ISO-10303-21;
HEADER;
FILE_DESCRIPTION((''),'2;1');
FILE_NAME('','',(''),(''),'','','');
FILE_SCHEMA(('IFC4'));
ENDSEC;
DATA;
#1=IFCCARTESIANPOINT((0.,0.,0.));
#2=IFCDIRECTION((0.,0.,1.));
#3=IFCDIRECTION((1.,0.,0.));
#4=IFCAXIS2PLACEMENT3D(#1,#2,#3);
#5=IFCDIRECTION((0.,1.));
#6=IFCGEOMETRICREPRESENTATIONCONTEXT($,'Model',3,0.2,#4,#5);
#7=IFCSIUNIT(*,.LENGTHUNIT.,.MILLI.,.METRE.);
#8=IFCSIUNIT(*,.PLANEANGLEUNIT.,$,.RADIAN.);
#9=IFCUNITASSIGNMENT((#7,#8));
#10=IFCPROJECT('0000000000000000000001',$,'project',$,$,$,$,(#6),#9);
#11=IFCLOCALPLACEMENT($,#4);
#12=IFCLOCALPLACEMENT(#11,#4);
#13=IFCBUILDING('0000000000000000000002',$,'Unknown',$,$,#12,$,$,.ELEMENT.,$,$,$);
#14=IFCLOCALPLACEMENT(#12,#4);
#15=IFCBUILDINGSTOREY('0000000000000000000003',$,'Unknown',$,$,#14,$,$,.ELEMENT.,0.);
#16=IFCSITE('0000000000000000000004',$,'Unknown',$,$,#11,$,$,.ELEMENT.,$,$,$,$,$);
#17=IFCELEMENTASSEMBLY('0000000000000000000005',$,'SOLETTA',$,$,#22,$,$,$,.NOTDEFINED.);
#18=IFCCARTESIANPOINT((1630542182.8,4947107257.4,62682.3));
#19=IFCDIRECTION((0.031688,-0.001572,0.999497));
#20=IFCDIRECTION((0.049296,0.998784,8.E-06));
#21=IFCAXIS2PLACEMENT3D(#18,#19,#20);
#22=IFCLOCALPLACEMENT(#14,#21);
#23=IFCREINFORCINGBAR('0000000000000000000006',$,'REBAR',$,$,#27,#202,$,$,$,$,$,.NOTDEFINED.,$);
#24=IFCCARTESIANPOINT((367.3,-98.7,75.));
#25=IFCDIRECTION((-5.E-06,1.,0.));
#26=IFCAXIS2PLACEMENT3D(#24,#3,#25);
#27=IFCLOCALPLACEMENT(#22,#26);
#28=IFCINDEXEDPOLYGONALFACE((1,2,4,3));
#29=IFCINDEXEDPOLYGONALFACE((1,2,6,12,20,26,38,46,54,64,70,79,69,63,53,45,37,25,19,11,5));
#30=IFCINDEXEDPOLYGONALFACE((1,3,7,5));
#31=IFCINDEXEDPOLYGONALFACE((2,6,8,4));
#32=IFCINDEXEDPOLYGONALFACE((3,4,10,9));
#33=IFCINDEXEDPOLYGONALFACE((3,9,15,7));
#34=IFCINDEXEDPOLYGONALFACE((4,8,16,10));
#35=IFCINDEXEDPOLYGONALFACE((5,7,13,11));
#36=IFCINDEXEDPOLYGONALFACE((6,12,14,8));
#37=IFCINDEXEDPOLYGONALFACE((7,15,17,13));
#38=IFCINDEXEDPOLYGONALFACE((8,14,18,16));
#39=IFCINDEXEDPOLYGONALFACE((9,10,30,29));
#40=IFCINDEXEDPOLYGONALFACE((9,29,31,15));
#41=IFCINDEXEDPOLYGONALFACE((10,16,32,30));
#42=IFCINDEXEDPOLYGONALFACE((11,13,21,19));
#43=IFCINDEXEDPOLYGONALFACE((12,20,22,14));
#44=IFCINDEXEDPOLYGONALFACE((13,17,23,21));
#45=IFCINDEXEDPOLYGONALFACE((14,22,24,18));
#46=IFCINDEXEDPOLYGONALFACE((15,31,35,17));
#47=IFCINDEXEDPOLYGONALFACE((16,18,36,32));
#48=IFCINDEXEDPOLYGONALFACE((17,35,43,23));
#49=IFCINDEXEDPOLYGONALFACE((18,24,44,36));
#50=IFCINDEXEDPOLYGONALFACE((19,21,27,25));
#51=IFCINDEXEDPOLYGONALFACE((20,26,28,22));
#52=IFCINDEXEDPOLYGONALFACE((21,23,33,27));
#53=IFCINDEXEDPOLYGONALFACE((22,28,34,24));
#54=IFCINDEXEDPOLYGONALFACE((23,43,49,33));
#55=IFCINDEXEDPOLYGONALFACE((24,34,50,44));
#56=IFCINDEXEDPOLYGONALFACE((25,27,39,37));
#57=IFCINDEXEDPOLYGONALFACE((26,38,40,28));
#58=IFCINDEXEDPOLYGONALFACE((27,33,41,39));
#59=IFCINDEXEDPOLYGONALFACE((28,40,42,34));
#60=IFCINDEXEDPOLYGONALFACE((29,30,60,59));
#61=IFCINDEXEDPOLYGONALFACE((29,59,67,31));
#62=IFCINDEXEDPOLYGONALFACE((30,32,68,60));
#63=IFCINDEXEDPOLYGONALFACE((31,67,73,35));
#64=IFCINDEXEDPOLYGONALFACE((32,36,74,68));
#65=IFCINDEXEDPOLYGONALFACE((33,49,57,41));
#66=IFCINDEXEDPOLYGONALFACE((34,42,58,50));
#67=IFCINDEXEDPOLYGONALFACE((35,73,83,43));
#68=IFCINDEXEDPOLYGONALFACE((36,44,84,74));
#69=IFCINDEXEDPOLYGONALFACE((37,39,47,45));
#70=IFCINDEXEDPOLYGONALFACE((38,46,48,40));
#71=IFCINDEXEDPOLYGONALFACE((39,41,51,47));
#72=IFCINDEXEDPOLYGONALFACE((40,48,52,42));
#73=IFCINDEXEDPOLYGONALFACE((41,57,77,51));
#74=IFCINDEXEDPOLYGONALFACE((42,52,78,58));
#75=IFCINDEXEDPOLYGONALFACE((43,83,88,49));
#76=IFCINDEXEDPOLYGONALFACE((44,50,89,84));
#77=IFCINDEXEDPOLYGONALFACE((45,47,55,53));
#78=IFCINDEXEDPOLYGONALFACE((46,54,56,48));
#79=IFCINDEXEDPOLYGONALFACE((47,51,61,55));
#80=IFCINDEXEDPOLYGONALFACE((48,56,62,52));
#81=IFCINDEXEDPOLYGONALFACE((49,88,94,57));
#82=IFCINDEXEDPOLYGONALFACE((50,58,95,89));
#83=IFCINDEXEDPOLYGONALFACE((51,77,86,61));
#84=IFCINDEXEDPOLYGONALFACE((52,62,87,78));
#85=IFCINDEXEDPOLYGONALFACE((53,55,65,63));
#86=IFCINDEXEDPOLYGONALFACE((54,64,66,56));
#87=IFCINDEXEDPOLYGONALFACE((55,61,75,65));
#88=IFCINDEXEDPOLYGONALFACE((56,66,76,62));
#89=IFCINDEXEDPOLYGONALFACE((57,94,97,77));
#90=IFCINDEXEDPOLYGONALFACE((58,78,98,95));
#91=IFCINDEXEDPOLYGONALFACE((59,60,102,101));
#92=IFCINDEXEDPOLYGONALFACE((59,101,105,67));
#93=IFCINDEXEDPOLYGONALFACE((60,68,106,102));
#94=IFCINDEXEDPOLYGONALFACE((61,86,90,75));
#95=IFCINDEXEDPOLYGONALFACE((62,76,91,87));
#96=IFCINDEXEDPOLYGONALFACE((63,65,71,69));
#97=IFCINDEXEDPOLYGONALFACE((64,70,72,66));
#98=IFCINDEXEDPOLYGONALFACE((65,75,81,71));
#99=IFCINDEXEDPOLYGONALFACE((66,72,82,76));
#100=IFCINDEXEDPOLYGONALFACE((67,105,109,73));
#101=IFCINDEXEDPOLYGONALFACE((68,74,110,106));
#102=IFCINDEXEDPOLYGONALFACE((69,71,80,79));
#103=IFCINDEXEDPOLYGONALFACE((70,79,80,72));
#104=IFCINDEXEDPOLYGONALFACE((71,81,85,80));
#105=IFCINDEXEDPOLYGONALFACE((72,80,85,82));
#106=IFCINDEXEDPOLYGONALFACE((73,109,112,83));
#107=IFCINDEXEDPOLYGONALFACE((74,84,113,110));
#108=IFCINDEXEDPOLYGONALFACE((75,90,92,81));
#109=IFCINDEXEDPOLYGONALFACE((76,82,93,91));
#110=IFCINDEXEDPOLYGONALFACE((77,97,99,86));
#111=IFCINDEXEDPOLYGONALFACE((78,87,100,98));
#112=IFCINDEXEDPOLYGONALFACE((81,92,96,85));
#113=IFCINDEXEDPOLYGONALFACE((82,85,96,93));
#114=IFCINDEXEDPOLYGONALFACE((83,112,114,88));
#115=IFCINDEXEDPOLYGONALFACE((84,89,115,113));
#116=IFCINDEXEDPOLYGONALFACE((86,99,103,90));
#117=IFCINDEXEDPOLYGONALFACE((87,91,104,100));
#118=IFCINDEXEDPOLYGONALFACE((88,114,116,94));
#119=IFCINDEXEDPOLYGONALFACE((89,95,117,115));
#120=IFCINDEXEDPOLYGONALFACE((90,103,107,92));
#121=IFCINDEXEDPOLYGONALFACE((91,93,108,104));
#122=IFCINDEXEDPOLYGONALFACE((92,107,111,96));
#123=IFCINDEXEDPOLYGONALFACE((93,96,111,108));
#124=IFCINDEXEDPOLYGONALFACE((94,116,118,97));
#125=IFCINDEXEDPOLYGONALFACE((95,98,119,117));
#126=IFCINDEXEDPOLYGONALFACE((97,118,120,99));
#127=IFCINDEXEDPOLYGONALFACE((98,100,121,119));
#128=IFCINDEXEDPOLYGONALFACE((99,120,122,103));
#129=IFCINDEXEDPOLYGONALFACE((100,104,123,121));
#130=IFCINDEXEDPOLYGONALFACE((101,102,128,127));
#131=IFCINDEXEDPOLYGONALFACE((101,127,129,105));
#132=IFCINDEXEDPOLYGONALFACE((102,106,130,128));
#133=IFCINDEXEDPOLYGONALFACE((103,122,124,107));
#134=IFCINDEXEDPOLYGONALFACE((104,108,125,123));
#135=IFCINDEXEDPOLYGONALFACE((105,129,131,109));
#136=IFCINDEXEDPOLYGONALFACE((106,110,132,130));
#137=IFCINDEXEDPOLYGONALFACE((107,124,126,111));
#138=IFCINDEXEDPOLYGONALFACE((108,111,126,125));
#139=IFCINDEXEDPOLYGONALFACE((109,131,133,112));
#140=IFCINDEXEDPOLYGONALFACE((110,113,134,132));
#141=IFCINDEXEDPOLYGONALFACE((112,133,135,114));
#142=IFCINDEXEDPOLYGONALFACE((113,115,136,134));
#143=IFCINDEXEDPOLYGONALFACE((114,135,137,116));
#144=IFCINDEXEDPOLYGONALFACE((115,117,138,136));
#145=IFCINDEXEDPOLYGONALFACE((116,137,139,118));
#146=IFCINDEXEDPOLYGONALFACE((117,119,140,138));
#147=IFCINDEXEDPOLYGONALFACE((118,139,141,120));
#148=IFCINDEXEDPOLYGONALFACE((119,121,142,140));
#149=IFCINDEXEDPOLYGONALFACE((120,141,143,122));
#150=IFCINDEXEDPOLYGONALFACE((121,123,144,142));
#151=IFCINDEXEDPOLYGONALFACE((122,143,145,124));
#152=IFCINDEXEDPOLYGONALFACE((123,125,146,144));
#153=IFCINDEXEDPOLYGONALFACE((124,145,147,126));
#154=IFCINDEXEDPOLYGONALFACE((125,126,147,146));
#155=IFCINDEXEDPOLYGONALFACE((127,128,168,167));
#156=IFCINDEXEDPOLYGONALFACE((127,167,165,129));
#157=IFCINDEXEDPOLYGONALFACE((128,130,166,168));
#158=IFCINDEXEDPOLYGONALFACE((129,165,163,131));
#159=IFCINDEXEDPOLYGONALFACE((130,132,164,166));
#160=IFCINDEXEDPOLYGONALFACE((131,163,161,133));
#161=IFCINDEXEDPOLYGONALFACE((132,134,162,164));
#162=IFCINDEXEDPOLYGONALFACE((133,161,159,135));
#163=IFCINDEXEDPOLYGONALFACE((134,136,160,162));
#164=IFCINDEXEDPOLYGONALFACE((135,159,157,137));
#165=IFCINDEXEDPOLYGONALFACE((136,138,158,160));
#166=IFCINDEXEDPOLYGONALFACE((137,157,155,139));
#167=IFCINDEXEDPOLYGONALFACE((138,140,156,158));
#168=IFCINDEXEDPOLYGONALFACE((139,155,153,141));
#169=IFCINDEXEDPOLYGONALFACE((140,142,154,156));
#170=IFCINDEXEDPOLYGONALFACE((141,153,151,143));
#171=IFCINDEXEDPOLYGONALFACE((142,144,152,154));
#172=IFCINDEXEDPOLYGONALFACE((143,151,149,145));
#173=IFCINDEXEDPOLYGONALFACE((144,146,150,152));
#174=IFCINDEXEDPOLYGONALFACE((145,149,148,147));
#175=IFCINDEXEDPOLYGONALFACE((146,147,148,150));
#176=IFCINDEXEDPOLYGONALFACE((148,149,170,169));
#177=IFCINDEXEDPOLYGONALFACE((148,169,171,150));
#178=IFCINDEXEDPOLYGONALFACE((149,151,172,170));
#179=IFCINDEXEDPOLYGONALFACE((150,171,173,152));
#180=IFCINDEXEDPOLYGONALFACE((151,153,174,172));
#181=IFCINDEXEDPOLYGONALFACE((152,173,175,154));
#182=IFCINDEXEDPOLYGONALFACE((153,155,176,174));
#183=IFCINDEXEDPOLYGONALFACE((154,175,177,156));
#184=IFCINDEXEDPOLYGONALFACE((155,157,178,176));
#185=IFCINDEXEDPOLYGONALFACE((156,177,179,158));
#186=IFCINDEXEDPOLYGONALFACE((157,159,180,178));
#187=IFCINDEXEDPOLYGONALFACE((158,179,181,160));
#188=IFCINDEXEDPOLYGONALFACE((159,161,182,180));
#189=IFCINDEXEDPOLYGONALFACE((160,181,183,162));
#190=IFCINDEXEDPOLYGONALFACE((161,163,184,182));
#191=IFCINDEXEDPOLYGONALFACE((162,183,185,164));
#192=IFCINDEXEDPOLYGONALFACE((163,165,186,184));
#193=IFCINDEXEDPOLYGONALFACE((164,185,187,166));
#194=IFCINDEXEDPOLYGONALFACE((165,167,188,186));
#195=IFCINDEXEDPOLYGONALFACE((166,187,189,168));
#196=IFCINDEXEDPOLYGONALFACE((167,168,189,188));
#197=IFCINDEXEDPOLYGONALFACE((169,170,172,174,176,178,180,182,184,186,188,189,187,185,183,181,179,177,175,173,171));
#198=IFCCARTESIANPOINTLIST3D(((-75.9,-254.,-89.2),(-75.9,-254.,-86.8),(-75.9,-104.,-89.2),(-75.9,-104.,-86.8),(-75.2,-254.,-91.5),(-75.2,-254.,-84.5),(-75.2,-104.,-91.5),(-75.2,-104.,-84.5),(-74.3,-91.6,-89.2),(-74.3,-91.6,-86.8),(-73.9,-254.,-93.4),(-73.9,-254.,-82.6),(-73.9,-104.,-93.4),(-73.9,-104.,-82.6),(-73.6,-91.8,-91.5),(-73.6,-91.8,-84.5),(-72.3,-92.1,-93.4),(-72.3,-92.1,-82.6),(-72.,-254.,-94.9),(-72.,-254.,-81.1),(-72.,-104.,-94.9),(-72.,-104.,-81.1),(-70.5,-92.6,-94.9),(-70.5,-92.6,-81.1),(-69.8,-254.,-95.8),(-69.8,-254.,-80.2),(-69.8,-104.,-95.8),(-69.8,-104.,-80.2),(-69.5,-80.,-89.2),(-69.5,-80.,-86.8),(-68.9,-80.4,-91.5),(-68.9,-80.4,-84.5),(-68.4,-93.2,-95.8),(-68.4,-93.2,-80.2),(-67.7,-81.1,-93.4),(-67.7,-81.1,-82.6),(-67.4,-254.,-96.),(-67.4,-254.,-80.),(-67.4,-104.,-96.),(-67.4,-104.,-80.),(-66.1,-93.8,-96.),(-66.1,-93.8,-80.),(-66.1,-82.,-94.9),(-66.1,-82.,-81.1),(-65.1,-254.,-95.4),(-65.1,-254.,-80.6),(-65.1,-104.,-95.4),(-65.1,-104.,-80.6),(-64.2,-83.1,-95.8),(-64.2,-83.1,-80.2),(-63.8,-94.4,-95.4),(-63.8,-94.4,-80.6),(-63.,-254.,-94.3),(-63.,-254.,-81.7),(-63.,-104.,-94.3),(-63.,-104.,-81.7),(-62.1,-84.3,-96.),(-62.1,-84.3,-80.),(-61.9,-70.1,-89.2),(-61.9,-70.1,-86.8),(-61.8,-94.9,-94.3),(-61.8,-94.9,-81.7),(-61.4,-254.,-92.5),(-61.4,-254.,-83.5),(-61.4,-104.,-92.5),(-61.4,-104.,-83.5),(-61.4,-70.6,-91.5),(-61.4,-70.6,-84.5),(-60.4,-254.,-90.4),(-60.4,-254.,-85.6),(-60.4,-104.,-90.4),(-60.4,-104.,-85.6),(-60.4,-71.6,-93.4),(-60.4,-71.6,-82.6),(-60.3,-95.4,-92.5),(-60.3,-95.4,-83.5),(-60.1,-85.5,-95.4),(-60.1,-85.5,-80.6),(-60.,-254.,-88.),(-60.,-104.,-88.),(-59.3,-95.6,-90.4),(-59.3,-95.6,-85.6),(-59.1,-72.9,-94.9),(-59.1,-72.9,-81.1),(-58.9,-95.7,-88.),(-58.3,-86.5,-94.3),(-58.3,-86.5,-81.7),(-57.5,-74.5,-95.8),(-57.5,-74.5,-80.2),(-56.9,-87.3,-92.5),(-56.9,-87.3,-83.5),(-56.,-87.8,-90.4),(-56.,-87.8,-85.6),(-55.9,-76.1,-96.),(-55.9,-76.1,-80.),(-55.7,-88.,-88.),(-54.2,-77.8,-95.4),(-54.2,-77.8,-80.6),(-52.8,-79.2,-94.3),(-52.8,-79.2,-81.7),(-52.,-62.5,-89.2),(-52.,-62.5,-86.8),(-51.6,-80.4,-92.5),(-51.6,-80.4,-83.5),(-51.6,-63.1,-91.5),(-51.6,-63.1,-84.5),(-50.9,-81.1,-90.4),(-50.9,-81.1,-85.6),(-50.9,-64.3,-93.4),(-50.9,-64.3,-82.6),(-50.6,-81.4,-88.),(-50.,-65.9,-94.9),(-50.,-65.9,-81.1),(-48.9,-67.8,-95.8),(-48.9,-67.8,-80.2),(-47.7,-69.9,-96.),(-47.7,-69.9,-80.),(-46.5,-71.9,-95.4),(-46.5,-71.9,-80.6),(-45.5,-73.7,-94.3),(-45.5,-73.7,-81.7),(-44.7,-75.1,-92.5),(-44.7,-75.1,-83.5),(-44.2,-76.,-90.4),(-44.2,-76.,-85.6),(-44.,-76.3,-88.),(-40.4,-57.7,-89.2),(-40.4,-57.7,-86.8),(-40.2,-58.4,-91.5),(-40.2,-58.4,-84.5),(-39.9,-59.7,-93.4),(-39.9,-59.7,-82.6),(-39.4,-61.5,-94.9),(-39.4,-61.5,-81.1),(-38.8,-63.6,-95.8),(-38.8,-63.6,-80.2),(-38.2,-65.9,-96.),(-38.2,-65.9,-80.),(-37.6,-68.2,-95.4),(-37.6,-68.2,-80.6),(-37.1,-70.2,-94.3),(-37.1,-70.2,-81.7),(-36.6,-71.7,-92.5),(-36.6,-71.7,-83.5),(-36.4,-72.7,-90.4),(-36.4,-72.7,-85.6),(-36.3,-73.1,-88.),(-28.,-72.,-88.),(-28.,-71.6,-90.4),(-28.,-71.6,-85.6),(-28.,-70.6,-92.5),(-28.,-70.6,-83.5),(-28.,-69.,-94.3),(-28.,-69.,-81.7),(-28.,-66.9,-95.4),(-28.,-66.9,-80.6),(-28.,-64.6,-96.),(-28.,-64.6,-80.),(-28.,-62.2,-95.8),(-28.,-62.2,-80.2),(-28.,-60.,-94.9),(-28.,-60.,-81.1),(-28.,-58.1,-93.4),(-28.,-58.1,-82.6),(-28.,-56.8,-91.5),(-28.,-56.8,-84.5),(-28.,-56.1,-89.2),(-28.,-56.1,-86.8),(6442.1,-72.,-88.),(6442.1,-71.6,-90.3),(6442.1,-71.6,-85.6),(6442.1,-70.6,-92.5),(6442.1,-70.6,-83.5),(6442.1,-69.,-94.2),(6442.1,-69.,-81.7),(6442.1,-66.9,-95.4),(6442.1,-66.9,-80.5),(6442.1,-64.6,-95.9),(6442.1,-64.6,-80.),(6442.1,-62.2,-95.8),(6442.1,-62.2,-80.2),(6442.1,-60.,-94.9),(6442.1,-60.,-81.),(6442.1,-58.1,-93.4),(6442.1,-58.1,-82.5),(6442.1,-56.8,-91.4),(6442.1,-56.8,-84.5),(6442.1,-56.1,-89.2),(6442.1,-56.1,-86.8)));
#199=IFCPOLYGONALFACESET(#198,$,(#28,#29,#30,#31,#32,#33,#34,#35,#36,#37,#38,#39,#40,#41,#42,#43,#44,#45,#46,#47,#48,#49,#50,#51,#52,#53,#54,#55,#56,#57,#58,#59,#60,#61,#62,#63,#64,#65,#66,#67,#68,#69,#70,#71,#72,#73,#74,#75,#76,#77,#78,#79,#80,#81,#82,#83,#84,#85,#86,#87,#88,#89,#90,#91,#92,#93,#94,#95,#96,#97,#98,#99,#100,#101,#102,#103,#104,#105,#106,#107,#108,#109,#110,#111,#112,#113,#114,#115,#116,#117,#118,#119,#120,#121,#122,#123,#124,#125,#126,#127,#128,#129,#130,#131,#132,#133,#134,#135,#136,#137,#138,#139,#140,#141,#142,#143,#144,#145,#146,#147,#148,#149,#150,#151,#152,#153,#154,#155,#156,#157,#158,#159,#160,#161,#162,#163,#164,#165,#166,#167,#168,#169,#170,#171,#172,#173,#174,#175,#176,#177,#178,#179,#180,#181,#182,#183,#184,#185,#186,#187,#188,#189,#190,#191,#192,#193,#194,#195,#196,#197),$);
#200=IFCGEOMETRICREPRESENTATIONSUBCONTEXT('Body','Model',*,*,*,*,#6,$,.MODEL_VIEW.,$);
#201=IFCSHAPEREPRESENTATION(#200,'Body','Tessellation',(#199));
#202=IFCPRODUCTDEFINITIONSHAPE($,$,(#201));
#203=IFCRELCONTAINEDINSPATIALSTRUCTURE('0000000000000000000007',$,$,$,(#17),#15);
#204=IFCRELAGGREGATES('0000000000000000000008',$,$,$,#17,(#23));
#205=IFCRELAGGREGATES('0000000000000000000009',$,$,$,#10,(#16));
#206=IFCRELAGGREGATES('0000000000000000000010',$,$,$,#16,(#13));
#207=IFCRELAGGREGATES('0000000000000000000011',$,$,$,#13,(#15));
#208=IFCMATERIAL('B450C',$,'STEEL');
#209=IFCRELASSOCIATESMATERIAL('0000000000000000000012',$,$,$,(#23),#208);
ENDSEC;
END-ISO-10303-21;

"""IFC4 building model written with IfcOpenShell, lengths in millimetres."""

from ifc_helpers import new_model, entity, si_unit, direction, frame, origin_with_axes, place, context, subcontext, project, spatial, material, element, aggregate, save


model = new_model("IFC4")

# Units and contexts
model_context = context("Model", 3, precision=0.2, world=origin_with_axes(), true_north=direction((0.0, 1.0)))
body_context = subcontext(model_context, "Body", "Model", "MODEL_VIEW")
ifc_project = project(units=[si_unit("LENGTHUNIT", "METRE", prefix="MILLI"), si_unit("PLANEANGLEUNIT", "RADIAN")], contexts=[model_context])

# Site, building, storey
site_placement = place(None, origin_with_axes())
site = spatial("IfcSite", under=ifc_project, at=site_placement, Name="Unknown", CompositionType="ELEMENT")
building_placement = place(site_placement, origin_with_axes())
building = spatial("IfcBuilding", under=site, at=building_placement, Name="Unknown", CompositionType="ELEMENT")
storey_placement = place(building_placement, origin_with_axes())
storey = spatial("IfcBuildingStorey", under=building, at=storey_placement, Name="Unknown", CompositionType="ELEMENT", Elevation=0.0)

# Element assembly, reinforcing bar
ifc_material = material(Name="B450C", Category="STEEL")
assembly_1_placement = place(storey_placement, frame((1630542182.8, 4947107257.4, 62682.3), z_axis=(0.031688, -0.001572, 0.999497), x_axis=(0.049296, 0.998784, 0.000008)))
assembly_1 = element("IfcElementAssembly", 1, at=assembly_1_placement, inside=storey, Name="SOLETTA", PredefinedType="NOTDEFINED")
reinforcing_bar_1_placement = place(assembly_1_placement, frame((367.3, -98.7, 75.0), z_axis=(1.0, 0.0, 0.0), x_axis=(-0.000005, 1.0, 0.0)))
reinforcing_bar_1 = element("IfcReinforcingBar", 2, at=reinforcing_bar_1_placement, material=ifc_material, Name="REBAR", PredefinedType="NOTDEFINED", context=body_context, shape_type="AdvancedSweptSolid", body=[
    entity("IfcSweptDiskSolid", entity("IfcIndexedPolyCurve", entity("IfcCartesianPointList3D", [[-68.0, -254.0, -88.0], [-68.0, -104.0, -88.0], [-56.3, -75.7, -88.0], [-28.0, -64.0, -88.0], [6442.1, -64.0, -88.0]]), [entity("IfcLineIndex", [1, 2]), entity("IfcArcIndex", [2, 3, 4]), entity("IfcLineIndex", [4, 5])]), 8.0),
])
aggregate(assembly_1, [reinforcing_bar_1])

save(model, "model.ifc")
